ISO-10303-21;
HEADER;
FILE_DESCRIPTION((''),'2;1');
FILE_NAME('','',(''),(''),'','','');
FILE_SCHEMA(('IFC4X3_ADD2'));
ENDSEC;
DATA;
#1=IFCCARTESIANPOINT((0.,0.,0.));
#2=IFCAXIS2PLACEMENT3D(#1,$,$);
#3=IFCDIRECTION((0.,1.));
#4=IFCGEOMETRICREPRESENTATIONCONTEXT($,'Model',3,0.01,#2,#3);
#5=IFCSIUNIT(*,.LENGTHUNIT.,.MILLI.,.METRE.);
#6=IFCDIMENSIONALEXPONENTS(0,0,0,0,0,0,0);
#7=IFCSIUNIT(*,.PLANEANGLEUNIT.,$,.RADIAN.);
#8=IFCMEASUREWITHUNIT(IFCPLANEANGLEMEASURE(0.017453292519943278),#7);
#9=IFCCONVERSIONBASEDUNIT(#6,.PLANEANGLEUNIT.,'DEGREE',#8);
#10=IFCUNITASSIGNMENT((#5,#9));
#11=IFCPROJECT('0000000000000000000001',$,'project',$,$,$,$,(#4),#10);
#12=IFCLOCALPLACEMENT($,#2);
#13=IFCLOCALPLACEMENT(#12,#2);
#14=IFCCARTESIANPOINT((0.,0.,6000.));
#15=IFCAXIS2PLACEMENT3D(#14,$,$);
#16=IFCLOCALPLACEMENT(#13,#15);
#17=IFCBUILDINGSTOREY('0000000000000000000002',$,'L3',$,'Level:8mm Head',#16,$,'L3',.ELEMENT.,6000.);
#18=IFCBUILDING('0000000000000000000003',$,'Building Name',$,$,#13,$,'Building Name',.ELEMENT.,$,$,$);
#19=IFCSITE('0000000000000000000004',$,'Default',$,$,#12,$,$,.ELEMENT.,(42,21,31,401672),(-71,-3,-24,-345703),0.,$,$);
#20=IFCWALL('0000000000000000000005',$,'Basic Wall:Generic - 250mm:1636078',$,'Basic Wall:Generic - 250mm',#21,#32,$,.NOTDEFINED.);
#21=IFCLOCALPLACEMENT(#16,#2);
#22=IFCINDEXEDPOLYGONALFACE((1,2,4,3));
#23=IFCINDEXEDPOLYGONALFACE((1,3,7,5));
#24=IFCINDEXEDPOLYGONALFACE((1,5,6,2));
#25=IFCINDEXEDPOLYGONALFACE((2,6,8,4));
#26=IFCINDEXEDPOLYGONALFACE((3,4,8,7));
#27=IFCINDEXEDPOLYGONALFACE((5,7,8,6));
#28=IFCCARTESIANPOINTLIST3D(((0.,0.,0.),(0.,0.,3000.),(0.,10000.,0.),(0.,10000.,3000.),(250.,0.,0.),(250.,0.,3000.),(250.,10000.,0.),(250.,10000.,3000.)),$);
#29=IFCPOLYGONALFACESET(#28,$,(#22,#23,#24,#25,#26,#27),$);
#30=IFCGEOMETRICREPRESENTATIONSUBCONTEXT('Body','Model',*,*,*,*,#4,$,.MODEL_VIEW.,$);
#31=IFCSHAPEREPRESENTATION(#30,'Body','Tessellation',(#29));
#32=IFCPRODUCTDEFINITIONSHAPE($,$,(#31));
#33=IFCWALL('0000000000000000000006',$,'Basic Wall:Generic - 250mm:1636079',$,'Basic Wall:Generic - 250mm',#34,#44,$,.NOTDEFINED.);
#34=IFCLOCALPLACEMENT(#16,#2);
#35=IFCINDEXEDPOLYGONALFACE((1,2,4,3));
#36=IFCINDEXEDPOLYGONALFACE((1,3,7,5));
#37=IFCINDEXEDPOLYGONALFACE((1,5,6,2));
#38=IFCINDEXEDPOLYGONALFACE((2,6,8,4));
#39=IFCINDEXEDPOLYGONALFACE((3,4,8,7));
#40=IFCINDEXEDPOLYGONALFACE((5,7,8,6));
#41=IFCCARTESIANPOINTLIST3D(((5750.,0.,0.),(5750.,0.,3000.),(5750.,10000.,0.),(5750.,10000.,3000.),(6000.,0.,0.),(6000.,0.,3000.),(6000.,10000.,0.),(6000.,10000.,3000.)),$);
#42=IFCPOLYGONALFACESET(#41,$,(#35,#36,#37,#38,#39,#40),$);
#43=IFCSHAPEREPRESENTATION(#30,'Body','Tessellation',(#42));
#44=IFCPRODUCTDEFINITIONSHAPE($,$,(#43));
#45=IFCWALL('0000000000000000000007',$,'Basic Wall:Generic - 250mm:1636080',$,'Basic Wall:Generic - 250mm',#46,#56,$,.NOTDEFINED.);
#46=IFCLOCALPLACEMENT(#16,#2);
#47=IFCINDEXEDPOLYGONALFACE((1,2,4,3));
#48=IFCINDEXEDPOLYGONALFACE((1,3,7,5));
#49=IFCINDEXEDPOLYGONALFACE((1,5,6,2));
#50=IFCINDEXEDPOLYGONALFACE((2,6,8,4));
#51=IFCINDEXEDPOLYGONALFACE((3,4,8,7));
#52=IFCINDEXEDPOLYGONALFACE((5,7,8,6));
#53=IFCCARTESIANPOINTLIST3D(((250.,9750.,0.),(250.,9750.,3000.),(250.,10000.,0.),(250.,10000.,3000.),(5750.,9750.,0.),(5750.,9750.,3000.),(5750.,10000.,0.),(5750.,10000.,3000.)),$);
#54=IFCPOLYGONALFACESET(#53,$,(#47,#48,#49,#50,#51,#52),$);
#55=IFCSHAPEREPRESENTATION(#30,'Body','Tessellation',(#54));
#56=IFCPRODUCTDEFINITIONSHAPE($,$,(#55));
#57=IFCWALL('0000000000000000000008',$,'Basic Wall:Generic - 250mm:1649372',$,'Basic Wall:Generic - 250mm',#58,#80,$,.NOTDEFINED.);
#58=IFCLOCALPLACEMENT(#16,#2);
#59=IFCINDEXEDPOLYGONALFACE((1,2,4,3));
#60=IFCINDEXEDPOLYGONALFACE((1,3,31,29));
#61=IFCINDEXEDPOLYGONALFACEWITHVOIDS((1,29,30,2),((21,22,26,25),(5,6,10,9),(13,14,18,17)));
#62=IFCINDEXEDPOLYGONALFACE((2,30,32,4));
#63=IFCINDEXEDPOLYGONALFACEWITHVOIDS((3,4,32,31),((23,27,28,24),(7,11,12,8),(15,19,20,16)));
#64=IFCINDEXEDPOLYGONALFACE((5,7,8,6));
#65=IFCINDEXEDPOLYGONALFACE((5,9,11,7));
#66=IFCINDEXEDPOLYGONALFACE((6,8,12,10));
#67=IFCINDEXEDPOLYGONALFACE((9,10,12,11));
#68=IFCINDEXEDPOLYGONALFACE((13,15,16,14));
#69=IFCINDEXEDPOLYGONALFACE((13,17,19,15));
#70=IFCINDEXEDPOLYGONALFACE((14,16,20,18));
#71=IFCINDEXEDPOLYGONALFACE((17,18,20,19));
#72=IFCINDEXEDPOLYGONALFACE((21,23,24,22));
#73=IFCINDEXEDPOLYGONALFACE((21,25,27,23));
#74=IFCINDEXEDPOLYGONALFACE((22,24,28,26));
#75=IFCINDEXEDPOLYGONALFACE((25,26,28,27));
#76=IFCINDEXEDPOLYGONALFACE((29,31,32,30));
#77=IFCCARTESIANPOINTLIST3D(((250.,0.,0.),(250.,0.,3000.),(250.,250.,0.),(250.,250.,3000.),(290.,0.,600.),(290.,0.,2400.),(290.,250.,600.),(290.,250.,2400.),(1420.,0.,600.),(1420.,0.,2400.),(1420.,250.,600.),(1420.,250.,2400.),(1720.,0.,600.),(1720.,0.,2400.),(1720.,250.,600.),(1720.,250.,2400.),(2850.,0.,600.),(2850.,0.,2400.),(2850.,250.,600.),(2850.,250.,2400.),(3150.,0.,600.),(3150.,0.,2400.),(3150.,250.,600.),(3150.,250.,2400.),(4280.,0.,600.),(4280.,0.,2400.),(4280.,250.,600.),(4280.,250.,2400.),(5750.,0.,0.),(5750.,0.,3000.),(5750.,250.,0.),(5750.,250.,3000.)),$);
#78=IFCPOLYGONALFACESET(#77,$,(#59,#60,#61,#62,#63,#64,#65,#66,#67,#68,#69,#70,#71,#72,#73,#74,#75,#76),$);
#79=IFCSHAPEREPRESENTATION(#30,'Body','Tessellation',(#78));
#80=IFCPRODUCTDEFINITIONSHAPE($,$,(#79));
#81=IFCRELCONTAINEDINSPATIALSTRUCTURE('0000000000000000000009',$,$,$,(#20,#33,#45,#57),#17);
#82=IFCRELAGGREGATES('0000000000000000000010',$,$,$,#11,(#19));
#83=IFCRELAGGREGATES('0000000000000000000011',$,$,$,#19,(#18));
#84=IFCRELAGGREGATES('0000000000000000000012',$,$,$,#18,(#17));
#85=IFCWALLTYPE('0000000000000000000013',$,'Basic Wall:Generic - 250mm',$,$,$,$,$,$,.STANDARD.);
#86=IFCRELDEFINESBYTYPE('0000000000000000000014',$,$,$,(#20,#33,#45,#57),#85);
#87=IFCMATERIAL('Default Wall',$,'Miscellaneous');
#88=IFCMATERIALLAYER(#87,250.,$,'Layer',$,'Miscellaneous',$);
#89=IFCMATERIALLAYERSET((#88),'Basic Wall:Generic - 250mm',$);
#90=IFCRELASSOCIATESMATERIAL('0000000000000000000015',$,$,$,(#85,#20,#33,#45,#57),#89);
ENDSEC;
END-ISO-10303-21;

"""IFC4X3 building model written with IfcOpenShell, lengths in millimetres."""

from ifc_helpers import new_model, entity, si_unit, converted_unit, direction, frame, frame_2d, origin, place, context, subcontext, project, spatial, rectangle, extrude, material, layer, layer_set, type_object, element, save


model = new_model("IFC4X3")

# Units and contexts
model_context = context("Model", 3, precision=0.01, world=origin(), true_north=direction((0.0, 1.0)))
body_context = subcontext(model_context, "Body", "Model", "MODEL_VIEW")
ifc_project = project(units=[si_unit("LENGTHUNIT", "METRE", prefix="MILLI"), converted_unit("PLANEANGLEUNIT", "DEGREE", entity("IfcPlaneAngleMeasure", 0.017453292519943278), si_unit("PLANEANGLEUNIT", "RADIAN"), dimensions=[0, 0, 0, 0, 0, 0, 0])], contexts=[model_context])

# Site, building, storey
site_placement = place(None, origin())
site = spatial("IfcSite", under=ifc_project, at=site_placement, Name="Default", CompositionType="ELEMENT", RefLatitude=(42, 21, 31, 401672), RefLongitude=(-71, -3, -24, -345703), RefElevation=0.0)
building_placement = place(site_placement, origin())
building = spatial("IfcBuilding", under=site, at=building_placement, Name="Building Name", LongName="Building Name", CompositionType="ELEMENT")
storey_placement = place(building_placement, frame((0.0, 0.0, 6000.0)))
storey = spatial("IfcBuildingStorey", under=building, at=storey_placement, Name="L3", ObjectType="Level:8mm Head", LongName="L3", CompositionType="ELEMENT", Elevation=6000.0)

# Walls
ifc_material = material(Name="Default Wall", Category="Miscellaneous")
ifc_layer = layer(ifc_material, 250.0, Name="Layer", Category="Miscellaneous")
ifc_layer_set = layer_set([ifc_layer], Name="Basic Wall:Generic - 250mm")
wall_type = type_object("IfcWallType", Name="Basic Wall:Generic - 250mm", PredefinedType="STANDARD", material=ifc_layer_set)
wall_1_placement = place(storey_placement, frame((125.0, 10000.0, 0.0), z_axis=(0.0, 0.0, 1.0), x_axis=(0.0, -1.0, 0.0)))
element("IfcWall", 1, at=wall_1_placement, inside=storey, type_object=wall_type, material=ifc_layer_set, Name="Basic Wall:Generic - 250mm:1636078", ObjectType="Basic Wall:Generic - 250mm", PredefinedType="NOTDEFINED", context=body_context, shape_type="SweptSolid", body=[
    extrude(rectangle(XDim=10000.0, YDim=250.0, at=frame_2d((5000.0, 0.0), x_axis=(-1.0, 0.0))), origin(), (0.0, 0.0, 1.0), 3000.0),
])
wall_2_placement = place(storey_placement, frame((5875.0, 0.0, 0.0), z_axis=(0.0, 0.0, 1.0), x_axis=(0.0, 1.0, 0.0)))
element("IfcWall", 2, at=wall_2_placement, inside=storey, type_object=wall_type, material=ifc_layer_set, Name="Basic Wall:Generic - 250mm:1636079", ObjectType="Basic Wall:Generic - 250mm", PredefinedType="NOTDEFINED", context=body_context, shape_type="SweptSolid", body=[
    extrude(rectangle(XDim=10000.0, YDim=250.0, at=frame_2d((5000.0, 0.0), x_axis=(-1.0, 0.0))), origin(), (0.0, 0.0, 1.0), 3000.0),
])
wall_3_placement = place(storey_placement, frame((5750.0, 9875.0, 0.0), z_axis=(0.0, 0.0, 1.0), x_axis=(-1.0, 0.0, 0.0)))
element("IfcWall", 3, at=wall_3_placement, inside=storey, type_object=wall_type, material=ifc_layer_set, Name="Basic Wall:Generic - 250mm:1636080", ObjectType="Basic Wall:Generic - 250mm", PredefinedType="NOTDEFINED", context=body_context, shape_type="SweptSolid", body=[
    extrude(rectangle(XDim=5500.0, YDim=250.0, at=frame_2d((2750.0, 0.0), x_axis=(-1.0, 0.0))), origin(), (0.0, 0.0, 1.0), 3000.0),
])

# Wall, openings
wall_4_placement = place(storey_placement, frame((250.0, 125.0, 0.0)))
wall_4 = element("IfcWall", 4, at=wall_4_placement, inside=storey, type_object=wall_type, material=ifc_layer_set, Name="Basic Wall:Generic - 250mm:1649372", ObjectType="Basic Wall:Generic - 250mm", PredefinedType="NOTDEFINED", context=body_context, shape_type="SweptSolid", body=[
    extrude(rectangle(XDim=5500.0, YDim=250.0, at=frame_2d((2750.0, 0.0), x_axis=(-1.0, 0.0))), origin(), (0.0, 0.0, 1.0), 3000.0),
])
opening_1_placement = place(wall_4_placement, frame((40.0, -125.0, 600.0)))
element("IfcOpeningElement", 5, at=opening_1_placement, cuts=wall_4, PredefinedType="OPENING", context=body_context, shape_type="SweptSolid", body=[
    extrude(rectangle(XDim=1800.0, YDim=1130.0, at=frame_2d((900.0, 565.0), x_axis=(-1.0, 0.0))), frame((0.0, 0.0, 0.0), z_axis=(0.0, 1.0, 0.0), x_axis=(0.0, 0.0, 1.0)), (0.0, 0.0, 1.0), 250.0),
])
opening_2_placement = place(wall_4_placement, frame((2900.0, -125.0, 600.0)))
element("IfcOpeningElement", 6, at=opening_2_placement, cuts=wall_4, PredefinedType="OPENING", context=body_context, shape_type="SweptSolid", body=[
    extrude(rectangle(XDim=1800.0, YDim=1130.0, at=frame_2d((900.0, 565.0), x_axis=(-1.0, 0.0))), frame((0.0, 0.0, 0.0), z_axis=(0.0, 1.0, 0.0), x_axis=(0.0, 0.0, 1.0)), (0.0, 0.0, 1.0), 250.0),
])
opening_3_placement = place(wall_4_placement, frame((1470.0, -125.0, 600.0)))
element("IfcOpeningElement", 7, at=opening_3_placement, cuts=wall_4, PredefinedType="OPENING", context=body_context, shape_type="SweptSolid", body=[
    extrude(rectangle(XDim=1800.0, YDim=1130.0, at=frame_2d((900.0, 565.0), x_axis=(-1.0, 0.0))), frame((0.0, 0.0, 0.0), z_axis=(0.0, 1.0, 0.0), x_axis=(0.0, 0.0, 1.0)), (0.0, 0.0, 1.0), 250.0),
])

save(model, "model.ifc")
